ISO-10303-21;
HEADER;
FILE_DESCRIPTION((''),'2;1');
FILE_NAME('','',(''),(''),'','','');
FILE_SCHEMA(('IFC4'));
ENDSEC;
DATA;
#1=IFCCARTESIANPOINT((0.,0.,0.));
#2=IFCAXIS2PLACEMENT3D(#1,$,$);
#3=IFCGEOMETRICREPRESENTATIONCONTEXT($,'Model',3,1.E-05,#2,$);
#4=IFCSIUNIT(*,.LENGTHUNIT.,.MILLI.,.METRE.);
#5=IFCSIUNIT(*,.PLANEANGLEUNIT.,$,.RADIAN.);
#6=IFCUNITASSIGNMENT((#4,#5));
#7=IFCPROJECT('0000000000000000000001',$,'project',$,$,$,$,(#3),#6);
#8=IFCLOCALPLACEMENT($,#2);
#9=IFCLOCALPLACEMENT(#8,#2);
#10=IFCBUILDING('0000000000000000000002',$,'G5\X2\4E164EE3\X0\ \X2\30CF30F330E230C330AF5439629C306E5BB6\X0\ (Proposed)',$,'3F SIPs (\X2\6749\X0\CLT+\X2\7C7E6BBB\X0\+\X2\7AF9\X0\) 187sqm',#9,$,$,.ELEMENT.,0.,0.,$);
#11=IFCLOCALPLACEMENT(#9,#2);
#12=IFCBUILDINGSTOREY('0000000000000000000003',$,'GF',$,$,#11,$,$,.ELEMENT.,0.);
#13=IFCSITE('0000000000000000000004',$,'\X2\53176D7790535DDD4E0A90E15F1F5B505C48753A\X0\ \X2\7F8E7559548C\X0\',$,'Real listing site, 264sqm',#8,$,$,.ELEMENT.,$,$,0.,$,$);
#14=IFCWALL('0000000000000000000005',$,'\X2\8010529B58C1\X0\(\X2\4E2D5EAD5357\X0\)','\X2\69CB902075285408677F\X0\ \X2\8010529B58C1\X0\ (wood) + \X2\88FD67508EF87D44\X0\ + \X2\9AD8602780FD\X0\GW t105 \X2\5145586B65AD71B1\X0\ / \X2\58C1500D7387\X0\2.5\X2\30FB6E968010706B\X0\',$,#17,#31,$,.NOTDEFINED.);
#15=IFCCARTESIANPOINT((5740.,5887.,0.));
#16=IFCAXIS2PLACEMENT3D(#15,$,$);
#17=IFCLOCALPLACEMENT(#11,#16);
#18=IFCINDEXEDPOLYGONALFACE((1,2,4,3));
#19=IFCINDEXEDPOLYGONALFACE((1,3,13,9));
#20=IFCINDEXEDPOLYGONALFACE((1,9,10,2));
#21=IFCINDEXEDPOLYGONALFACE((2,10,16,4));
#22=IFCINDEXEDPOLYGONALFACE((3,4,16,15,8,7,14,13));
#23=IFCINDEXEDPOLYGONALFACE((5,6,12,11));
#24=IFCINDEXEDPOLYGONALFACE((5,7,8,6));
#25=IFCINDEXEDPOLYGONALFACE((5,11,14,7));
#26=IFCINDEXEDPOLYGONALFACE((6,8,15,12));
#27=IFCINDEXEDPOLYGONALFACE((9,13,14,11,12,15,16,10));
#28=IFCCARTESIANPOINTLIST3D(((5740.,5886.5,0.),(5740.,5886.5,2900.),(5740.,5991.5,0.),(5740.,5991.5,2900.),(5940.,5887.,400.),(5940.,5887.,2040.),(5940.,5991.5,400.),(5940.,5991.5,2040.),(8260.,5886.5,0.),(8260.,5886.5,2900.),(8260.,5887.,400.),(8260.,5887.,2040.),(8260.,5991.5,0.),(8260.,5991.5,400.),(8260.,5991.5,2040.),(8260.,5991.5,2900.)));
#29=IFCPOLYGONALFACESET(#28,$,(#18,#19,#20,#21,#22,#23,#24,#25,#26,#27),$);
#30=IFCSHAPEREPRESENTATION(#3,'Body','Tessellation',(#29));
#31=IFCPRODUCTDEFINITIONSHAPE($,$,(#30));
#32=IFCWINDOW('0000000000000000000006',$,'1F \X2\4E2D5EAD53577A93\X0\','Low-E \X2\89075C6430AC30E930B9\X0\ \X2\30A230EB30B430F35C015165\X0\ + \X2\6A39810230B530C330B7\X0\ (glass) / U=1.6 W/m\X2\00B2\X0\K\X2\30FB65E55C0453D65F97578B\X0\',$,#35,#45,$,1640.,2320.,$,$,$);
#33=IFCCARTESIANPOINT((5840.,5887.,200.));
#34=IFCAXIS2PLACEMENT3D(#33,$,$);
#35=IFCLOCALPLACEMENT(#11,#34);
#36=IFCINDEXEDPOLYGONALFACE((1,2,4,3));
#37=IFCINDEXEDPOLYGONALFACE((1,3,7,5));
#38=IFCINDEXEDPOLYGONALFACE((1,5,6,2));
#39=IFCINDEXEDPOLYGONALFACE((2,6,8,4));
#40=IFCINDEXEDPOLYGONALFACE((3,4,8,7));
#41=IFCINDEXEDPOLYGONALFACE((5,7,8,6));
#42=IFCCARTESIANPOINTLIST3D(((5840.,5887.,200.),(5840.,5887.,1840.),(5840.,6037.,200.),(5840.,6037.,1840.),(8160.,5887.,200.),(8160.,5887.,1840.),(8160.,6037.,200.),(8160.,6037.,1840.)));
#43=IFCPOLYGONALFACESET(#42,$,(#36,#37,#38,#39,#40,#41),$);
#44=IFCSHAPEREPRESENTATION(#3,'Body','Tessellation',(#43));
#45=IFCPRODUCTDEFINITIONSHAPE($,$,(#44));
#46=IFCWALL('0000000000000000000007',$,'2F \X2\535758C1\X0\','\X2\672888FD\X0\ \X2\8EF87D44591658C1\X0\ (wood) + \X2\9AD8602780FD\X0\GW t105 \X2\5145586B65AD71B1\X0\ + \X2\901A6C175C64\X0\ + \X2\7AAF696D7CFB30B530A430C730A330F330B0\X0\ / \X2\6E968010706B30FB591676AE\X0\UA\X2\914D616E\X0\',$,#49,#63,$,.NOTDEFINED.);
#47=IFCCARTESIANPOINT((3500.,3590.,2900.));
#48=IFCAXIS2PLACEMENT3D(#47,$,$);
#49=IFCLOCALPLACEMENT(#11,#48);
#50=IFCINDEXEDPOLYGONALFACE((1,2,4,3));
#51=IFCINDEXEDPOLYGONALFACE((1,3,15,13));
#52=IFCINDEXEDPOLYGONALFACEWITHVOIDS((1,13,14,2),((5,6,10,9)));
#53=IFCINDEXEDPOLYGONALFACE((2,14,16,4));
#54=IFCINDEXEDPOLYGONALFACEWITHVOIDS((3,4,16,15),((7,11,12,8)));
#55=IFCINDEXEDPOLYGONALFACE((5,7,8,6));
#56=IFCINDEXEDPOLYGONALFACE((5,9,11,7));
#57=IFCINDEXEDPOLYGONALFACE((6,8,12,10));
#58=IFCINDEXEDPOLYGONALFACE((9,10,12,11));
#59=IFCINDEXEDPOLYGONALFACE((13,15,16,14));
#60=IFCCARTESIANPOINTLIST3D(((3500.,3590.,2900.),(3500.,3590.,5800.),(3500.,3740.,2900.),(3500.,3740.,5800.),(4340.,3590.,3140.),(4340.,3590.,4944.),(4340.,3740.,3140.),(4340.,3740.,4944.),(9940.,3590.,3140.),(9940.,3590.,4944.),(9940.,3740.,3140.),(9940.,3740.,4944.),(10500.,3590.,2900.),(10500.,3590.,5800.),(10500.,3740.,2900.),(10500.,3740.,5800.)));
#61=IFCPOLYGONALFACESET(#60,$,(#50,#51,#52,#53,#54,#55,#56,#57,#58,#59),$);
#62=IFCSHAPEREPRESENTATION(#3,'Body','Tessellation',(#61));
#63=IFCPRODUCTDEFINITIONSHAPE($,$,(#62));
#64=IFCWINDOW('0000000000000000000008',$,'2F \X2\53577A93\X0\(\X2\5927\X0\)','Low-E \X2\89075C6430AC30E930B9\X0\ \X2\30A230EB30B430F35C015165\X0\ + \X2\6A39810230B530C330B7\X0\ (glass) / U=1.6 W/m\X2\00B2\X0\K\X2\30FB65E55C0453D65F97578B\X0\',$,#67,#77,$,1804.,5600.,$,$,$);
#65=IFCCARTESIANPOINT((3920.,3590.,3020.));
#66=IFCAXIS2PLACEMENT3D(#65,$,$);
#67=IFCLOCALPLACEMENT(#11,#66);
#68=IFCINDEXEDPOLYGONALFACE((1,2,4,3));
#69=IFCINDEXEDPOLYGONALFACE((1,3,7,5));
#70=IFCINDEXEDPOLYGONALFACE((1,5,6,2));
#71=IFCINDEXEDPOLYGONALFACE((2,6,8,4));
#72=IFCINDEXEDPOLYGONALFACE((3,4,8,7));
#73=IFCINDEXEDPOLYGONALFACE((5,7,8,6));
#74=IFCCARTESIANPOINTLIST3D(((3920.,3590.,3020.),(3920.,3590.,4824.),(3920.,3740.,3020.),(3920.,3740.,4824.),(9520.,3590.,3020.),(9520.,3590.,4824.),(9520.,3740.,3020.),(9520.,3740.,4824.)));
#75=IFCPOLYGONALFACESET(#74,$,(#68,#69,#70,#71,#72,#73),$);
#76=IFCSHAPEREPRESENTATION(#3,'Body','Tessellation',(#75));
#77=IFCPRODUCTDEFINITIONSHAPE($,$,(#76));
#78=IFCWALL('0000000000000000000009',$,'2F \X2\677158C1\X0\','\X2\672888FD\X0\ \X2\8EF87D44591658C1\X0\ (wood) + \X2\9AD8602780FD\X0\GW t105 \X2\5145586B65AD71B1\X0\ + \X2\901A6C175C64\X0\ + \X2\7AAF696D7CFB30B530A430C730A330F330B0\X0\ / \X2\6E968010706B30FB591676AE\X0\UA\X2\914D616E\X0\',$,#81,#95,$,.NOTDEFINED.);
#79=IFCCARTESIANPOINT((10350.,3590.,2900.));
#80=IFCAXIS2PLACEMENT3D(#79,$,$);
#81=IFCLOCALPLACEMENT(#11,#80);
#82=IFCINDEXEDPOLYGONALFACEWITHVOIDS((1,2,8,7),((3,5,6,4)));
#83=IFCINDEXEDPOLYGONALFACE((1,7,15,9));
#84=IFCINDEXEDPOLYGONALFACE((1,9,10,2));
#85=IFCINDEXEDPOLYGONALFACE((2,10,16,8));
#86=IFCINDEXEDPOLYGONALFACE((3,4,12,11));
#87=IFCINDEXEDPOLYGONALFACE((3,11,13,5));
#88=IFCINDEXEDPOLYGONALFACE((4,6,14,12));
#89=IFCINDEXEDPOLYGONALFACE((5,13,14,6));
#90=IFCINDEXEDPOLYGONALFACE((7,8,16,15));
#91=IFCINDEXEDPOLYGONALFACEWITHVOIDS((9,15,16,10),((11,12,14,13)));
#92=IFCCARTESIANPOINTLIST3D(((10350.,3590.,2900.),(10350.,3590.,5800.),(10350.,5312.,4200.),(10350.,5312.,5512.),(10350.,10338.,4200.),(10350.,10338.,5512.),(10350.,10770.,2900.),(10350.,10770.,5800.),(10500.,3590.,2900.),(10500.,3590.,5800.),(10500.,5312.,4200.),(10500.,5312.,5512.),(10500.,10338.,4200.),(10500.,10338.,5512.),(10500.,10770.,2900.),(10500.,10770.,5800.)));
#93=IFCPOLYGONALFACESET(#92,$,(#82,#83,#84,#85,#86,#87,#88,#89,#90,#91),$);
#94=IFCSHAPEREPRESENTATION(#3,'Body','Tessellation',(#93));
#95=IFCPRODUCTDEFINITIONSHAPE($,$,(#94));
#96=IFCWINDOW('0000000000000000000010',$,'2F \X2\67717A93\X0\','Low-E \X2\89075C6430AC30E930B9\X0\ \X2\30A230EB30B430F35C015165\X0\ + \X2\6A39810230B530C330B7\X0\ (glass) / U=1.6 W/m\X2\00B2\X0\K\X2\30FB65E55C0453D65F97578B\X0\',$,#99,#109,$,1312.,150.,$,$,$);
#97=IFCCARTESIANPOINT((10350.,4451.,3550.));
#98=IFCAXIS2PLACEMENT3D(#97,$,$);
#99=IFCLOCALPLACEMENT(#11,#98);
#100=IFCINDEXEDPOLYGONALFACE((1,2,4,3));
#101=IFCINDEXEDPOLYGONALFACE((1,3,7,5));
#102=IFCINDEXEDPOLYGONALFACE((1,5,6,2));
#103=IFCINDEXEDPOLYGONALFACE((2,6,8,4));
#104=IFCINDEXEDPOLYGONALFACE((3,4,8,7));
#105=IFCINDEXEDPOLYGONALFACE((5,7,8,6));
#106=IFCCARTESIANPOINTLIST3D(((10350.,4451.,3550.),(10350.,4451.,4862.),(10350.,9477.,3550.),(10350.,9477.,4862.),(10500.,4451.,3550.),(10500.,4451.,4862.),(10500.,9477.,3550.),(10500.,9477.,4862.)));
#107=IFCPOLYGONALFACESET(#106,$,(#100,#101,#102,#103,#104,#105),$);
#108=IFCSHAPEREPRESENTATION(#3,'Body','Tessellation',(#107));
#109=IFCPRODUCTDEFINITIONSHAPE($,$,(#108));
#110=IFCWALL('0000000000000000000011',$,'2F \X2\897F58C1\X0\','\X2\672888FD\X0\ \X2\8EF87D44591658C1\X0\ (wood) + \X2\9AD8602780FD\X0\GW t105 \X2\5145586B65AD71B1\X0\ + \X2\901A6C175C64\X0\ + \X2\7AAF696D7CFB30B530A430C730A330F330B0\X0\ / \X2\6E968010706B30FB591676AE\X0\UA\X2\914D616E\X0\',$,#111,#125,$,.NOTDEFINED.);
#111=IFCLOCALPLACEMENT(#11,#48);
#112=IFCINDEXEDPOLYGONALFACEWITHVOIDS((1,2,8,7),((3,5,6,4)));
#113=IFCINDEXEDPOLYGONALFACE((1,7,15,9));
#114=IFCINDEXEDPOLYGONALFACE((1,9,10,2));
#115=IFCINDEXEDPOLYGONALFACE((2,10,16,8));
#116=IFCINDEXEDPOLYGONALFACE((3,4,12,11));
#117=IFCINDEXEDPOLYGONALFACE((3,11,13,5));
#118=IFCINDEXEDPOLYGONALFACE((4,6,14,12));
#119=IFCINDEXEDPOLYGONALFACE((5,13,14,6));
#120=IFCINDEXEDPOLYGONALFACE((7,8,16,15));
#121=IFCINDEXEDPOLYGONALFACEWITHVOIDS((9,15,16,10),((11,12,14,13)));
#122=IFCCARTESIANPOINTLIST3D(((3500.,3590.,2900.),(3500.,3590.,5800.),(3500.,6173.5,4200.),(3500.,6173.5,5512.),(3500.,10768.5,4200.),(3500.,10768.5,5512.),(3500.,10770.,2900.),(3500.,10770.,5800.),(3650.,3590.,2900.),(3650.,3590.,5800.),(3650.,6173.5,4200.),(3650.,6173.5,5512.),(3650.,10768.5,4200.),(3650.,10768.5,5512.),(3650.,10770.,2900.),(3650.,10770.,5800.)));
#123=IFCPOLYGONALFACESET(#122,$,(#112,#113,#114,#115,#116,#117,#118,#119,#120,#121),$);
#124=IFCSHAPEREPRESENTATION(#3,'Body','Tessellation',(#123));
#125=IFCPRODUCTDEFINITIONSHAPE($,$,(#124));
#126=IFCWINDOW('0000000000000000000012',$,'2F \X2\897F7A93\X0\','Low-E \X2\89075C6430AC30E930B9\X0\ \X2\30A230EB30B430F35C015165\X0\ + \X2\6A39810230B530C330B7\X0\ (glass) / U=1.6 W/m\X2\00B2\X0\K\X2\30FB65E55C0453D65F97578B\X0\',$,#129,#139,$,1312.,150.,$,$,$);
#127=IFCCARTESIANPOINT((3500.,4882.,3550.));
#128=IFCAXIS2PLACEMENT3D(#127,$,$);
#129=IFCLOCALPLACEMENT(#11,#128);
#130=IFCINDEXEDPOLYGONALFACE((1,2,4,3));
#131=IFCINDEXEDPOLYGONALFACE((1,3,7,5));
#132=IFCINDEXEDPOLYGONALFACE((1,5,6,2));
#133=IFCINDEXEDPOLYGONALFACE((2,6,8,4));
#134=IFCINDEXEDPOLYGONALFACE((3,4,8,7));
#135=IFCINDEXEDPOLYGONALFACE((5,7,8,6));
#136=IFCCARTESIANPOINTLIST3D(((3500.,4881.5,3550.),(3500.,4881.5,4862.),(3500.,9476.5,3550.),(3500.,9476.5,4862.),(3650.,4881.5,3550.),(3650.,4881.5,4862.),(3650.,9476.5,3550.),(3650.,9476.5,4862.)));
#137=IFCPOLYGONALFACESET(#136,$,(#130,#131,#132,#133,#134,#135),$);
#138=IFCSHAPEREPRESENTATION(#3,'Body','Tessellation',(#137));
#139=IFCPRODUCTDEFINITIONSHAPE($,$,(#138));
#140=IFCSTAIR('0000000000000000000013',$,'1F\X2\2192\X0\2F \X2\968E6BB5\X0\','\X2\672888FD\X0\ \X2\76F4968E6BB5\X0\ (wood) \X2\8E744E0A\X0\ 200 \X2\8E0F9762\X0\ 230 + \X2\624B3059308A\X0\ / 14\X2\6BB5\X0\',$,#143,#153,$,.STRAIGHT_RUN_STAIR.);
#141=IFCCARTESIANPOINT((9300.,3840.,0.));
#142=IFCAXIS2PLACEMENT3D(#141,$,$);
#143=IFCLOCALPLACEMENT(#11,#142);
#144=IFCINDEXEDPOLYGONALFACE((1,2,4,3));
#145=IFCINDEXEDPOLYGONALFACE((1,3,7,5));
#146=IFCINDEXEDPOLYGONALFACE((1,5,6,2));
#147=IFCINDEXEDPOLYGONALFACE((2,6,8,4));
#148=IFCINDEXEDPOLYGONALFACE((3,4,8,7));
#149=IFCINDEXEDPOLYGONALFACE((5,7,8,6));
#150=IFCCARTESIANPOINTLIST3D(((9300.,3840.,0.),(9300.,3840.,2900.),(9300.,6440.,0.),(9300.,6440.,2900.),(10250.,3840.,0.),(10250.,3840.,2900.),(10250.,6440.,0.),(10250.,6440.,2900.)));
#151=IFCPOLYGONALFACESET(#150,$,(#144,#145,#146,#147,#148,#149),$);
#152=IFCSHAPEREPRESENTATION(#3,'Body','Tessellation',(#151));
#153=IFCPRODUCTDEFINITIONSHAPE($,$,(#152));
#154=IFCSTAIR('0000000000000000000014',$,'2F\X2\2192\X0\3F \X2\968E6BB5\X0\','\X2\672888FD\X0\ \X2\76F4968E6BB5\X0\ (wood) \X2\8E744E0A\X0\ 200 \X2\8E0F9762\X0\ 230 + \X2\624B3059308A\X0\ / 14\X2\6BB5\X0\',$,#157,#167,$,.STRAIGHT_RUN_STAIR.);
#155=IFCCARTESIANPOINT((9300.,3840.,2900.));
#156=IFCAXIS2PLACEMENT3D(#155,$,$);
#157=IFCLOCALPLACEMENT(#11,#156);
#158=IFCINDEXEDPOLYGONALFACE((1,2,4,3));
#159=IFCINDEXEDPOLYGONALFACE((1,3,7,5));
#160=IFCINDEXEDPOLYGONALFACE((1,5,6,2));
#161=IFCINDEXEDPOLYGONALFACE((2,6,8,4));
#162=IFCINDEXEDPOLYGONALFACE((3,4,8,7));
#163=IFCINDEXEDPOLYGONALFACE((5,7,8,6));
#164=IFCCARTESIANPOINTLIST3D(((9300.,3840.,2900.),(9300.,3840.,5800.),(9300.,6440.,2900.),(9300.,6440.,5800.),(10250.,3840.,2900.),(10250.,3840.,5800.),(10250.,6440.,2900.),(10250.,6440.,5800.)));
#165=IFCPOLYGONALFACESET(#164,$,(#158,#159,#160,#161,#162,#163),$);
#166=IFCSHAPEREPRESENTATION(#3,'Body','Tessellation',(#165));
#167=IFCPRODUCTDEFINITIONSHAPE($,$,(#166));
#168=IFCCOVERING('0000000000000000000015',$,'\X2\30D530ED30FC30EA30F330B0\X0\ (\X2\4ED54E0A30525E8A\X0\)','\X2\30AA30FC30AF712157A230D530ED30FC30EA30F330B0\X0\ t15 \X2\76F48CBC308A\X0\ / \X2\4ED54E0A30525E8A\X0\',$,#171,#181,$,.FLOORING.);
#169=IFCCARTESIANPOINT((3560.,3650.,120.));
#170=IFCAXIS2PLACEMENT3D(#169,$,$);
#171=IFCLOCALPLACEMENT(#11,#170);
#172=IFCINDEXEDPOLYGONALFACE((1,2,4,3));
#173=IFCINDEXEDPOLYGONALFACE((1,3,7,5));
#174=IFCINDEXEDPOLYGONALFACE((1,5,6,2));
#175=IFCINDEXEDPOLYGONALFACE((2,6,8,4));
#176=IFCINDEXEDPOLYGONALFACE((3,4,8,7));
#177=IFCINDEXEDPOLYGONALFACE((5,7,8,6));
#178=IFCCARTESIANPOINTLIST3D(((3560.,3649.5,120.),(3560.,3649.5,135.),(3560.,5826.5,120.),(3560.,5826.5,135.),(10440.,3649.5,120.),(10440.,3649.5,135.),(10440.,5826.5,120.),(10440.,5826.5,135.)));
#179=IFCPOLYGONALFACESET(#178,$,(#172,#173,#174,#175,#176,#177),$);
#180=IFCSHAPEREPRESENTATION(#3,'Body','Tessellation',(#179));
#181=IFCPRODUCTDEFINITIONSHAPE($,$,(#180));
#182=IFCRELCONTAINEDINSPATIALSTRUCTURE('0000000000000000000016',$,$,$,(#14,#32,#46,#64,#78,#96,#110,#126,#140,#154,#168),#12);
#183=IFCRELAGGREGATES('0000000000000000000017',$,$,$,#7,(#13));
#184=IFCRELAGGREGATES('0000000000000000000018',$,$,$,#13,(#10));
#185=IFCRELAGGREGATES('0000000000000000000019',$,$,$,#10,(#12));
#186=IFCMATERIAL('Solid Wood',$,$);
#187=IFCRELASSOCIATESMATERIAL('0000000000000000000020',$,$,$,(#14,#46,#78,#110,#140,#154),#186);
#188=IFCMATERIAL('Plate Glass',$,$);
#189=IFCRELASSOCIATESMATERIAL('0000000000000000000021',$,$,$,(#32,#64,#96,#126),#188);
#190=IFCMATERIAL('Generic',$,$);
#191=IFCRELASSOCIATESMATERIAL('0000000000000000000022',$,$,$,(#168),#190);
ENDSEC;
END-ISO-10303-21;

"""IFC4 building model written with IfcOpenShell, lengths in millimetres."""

from ifc_helpers import new_model, si_unit, frame, frame_2d, origin, place, context, project, spatial, rectangle, extrude, material, element, fill, save


model = new_model("IFC4")

# Units and contexts
model_context = context("Model", 3, precision=1e-05, world=origin())
ifc_project = project(units=[si_unit("LENGTHUNIT", "METRE", prefix="MILLI"), si_unit("PLANEANGLEUNIT", "RADIAN")], contexts=[model_context])

# Site, building, storey
site_placement = place(None, origin())
site = spatial("IfcSite", under=ifc_project, at=site_placement, Name="北海道川上郡弟子屈町 美留和", ObjectType="Real listing site, 264sqm", CompositionType="ELEMENT", RefElevation=0.0)
building_placement = place(site_placement, origin())
building = spatial("IfcBuilding", under=site, at=building_placement, Name="G5世代 ハンモック吹抜の家 (Proposed)", ObjectType="3F SIPs (杉CLT+籾殻+竹) 187sqm", CompositionType="ELEMENT", ElevationOfRefHeight=0.0, ElevationOfTerrain=0.0)
storey_placement = place(building_placement, origin())
storey = spatial("IfcBuildingStorey", under=building, at=storey_placement, Name="GF", CompositionType="ELEMENT", Elevation=0.0)

# Shared definitions
ifc_material_1 = material(Name="Solid Wood")

# Shared definitions
ifc_material_2 = material(Name="Plate Glass")

# Walls, openings, windows
wall_1_placement = place(storey_placement, frame((5740.0, 5887.0, 0.0)))
wall_1 = element("IfcWall", 1, at=wall_1_placement, inside=storey, material=ifc_material_1, Name="耐力壁(中庭南)", Description="構造用合板 耐力壁 (wood) + 製材軸組 + 高性能GW t105 充填断熱 / 壁倍率2.5・準耐火", PredefinedType="NOTDEFINED", context=model_context, shape_type="SweptSolid", body=[
    extrude(rectangle(XDim=2520.0, YDim=105.0, at=frame_2d((1260.0, 52.0))), frame((5740.0, 5887.0, 0.0)), (0.0, 0.0, 1.0), 2900.0),
])
opening_1_placement = place(storey_placement, frame((5840.0, 5887.0, 200.0)))
opening_1 = element("IfcOpeningElement", 2, at=opening_1_placement, cuts=wall_1, PredefinedType="NOTDEFINED", context=model_context, shape_type="SweptSolid", body=[
    extrude(rectangle(XDim=2320.0, YDim=150.0, at=frame_2d((1160.0, 75.0))), frame((5840.0, 5887.0, 200.0)), (0.0, 0.0, 1.0), 1640.0),
])
window_1_placement = place(storey_placement, frame((5840.0, 5887.0, 200.0)))
window_1 = element("IfcWindow", 3, at=window_1_placement, inside=storey, material=ifc_material_2, Name="1F 中庭南窓", Description="Low-E 複層ガラス アルゴン封入 + 樹脂サッシ (glass) / U=1.6 W/m²K・日射取得型", OverallHeight=1640.0, OverallWidth=2320.0, context=model_context, shape_type="SweptSolid", body=[
    extrude(rectangle(XDim=2320.0, YDim=150.0, at=frame_2d((1160.0, 75.0))), frame((5840.0, 5887.0, 200.0)), (0.0, 0.0, 1.0), 1640.0),
])
fill(opening_1, window_1)
wall_2_placement = place(storey_placement, frame((3500.0, 3590.0, 2900.0)))
wall_2 = element("IfcWall", 4, at=wall_2_placement, inside=storey, material=ifc_material_1, Name="2F 南壁", Description="木製 軸組外壁 (wood) + 高性能GW t105 充填断熱 + 通気層 + 窯業系サイディング / 準耐火・外皮UA配慮", PredefinedType="NOTDEFINED", context=model_context, shape_type="SweptSolid", body=[
    extrude(rectangle(XDim=7000.0, YDim=150.0, at=frame_2d((3500.0, 75.0))), frame((3500.0, 3590.0, 2900.0)), (0.0, 0.0, 1.0), 2900.0),
])
opening_2_placement = place(storey_placement, frame((3920.0, 3590.0, 3020.0)))
opening_2 = element("IfcOpeningElement", 5, at=opening_2_placement, cuts=wall_2, PredefinedType="NOTDEFINED", context=model_context, shape_type="SweptSolid", body=[
    extrude(rectangle(XDim=5600.0, YDim=150.0, at=frame_2d((2800.0, 75.0))), frame((3920.0, 3590.0, 3020.0)), (0.0, 0.0, 1.0), 1804.0),
])
window_2_placement = place(storey_placement, frame((3920.0, 3590.0, 3020.0)))
window_2 = element("IfcWindow", 6, at=window_2_placement, inside=storey, material=ifc_material_2, Name="2F 南窓(大)", Description="Low-E 複層ガラス アルゴン封入 + 樹脂サッシ (glass) / U=1.6 W/m²K・日射取得型", OverallHeight=1804.0, OverallWidth=5600.0, context=model_context, shape_type="SweptSolid", body=[
    extrude(rectangle(XDim=5600.0, YDim=150.0, at=frame_2d((2800.0, 75.0))), frame((3920.0, 3590.0, 3020.0)), (0.0, 0.0, 1.0), 1804.0),
])
fill(opening_2, window_2)
wall_3_placement = place(storey_placement, frame((10350.0, 3590.0, 2900.0)))
wall_3 = element("IfcWall", 7, at=wall_3_placement, inside=storey, material=ifc_material_1, Name="2F 東壁", Description="木製 軸組外壁 (wood) + 高性能GW t105 充填断熱 + 通気層 + 窯業系サイディング / 準耐火・外皮UA配慮", PredefinedType="NOTDEFINED", context=model_context, shape_type="SweptSolid", body=[
    extrude(rectangle(XDim=150.0, YDim=7180.0, at=frame_2d((75.0, 3590.0))), frame((10350.0, 3590.0, 2900.0)), (0.0, 0.0, 1.0), 2900.0),
])
opening_3_placement = place(storey_placement, frame((10350.0, 4451.0, 3550.0)))
opening_3 = element("IfcOpeningElement", 8, at=opening_3_placement, cuts=wall_3, PredefinedType="NOTDEFINED", context=model_context, shape_type="SweptSolid", body=[
    extrude(rectangle(XDim=150.0, YDim=5026.0, at=frame_2d((75.0, 2513.0))), frame((10350.0, 4451.0, 3550.0)), (0.0, 0.0, 1.0), 1312.0),
])
window_3_placement = place(storey_placement, frame((10350.0, 4451.0, 3550.0)))
window_3 = element("IfcWindow", 9, at=window_3_placement, inside=storey, material=ifc_material_2, Name="2F 東窓", Description="Low-E 複層ガラス アルゴン封入 + 樹脂サッシ (glass) / U=1.6 W/m²K・日射取得型", OverallHeight=1312.0, OverallWidth=150.0, context=model_context, shape_type="SweptSolid", body=[
    extrude(rectangle(XDim=150.0, YDim=5026.0, at=frame_2d((75.0, 2513.0))), frame((10350.0, 4451.0, 3550.0)), (0.0, 0.0, 1.0), 1312.0),
])
fill(opening_3, window_3)
wall_4_placement = place(storey_placement, frame((3500.0, 3590.0, 2900.0)))
wall_4 = element("IfcWall", 10, at=wall_4_placement, inside=storey, material=ifc_material_1, Name="2F 西壁", Description="木製 軸組外壁 (wood) + 高性能GW t105 充填断熱 + 通気層 + 窯業系サイディング / 準耐火・外皮UA配慮", PredefinedType="NOTDEFINED", context=model_context, shape_type="SweptSolid", body=[
    extrude(rectangle(XDim=150.0, YDim=7180.0, at=frame_2d((75.0, 3590.0))), frame((3500.0, 3590.0, 2900.0)), (0.0, 0.0, 1.0), 2900.0),
])
opening_4_placement = place(storey_placement, frame((3500.0, 4882.0, 3550.0)))
opening_4 = element("IfcOpeningElement", 11, at=opening_4_placement, cuts=wall_4, PredefinedType="NOTDEFINED", context=model_context, shape_type="SweptSolid", body=[
    extrude(rectangle(XDim=150.0, YDim=4595.0, at=frame_2d((75.0, 2297.0))), frame((3500.0, 4882.0, 3550.0)), (0.0, 0.0, 1.0), 1312.0),
])
window_4_placement = place(storey_placement, frame((3500.0, 4882.0, 3550.0)))
window_4 = element("IfcWindow", 12, at=window_4_placement, inside=storey, material=ifc_material_2, Name="2F 西窓", Description="Low-E 複層ガラス アルゴン封入 + 樹脂サッシ (glass) / U=1.6 W/m²K・日射取得型", OverallHeight=1312.0, OverallWidth=150.0, context=model_context, shape_type="SweptSolid", body=[
    extrude(rectangle(XDim=150.0, YDim=4595.0, at=frame_2d((75.0, 2297.0))), frame((3500.0, 4882.0, 3550.0)), (0.0, 0.0, 1.0), 1312.0),
])
fill(opening_4, window_4)

# Stairs
stair_1_placement = place(storey_placement, frame((9300.0, 3840.0, 0.0)))
element("IfcStair", 13, at=stair_1_placement, inside=storey, material=ifc_material_1, Name="1F→2F 階段", Description="木製 直階段 (wood) 蹴上 200 踏面 230 + 手すり / 14段", PredefinedType="STRAIGHT_RUN_STAIR", context=model_context, shape_type="SweptSolid", body=[
    extrude(rectangle(XDim=950.0, YDim=2600.0, at=frame_2d((475.0, 1300.0))), frame((9300.0, 3840.0, 0.0)), (0.0, 0.0, 1.0), 2900.0),
])
stair_2_placement = place(storey_placement, frame((9300.0, 3840.0, 2900.0)))
element("IfcStair", 14, at=stair_2_placement, inside=storey, material=ifc_material_1, Name="2F→3F 階段", Description="木製 直階段 (wood) 蹴上 200 踏面 230 + 手すり / 14段", PredefinedType="STRAIGHT_RUN_STAIR", context=model_context, shape_type="SweptSolid", body=[
    extrude(rectangle(XDim=950.0, YDim=2600.0, at=frame_2d((475.0, 1300.0))), frame((9300.0, 3840.0, 2900.0)), (0.0, 0.0, 1.0), 2900.0),
])

# Covering
ifc_material_3 = material(Name="Generic")
covering_placement = place(storey_placement, frame((3560.0, 3650.0, 120.0)))
element("IfcCovering", 15, at=covering_placement, inside=storey, material=ifc_material_3, Name="フローリング (仕上げ床)", Description="オーク無垢フローリング t15 直貼り / 仕上げ床", PredefinedType="FLOORING", context=model_context, shape_type="SweptSolid", body=[
    extrude(rectangle(XDim=6880.0, YDim=2177.0, at=frame_2d((3440.0, 1088.0))), frame((3560.0, 3650.0, 120.0)), (0.0, 0.0, 1.0), 15.0),
])

save(model, "model.ifc")
